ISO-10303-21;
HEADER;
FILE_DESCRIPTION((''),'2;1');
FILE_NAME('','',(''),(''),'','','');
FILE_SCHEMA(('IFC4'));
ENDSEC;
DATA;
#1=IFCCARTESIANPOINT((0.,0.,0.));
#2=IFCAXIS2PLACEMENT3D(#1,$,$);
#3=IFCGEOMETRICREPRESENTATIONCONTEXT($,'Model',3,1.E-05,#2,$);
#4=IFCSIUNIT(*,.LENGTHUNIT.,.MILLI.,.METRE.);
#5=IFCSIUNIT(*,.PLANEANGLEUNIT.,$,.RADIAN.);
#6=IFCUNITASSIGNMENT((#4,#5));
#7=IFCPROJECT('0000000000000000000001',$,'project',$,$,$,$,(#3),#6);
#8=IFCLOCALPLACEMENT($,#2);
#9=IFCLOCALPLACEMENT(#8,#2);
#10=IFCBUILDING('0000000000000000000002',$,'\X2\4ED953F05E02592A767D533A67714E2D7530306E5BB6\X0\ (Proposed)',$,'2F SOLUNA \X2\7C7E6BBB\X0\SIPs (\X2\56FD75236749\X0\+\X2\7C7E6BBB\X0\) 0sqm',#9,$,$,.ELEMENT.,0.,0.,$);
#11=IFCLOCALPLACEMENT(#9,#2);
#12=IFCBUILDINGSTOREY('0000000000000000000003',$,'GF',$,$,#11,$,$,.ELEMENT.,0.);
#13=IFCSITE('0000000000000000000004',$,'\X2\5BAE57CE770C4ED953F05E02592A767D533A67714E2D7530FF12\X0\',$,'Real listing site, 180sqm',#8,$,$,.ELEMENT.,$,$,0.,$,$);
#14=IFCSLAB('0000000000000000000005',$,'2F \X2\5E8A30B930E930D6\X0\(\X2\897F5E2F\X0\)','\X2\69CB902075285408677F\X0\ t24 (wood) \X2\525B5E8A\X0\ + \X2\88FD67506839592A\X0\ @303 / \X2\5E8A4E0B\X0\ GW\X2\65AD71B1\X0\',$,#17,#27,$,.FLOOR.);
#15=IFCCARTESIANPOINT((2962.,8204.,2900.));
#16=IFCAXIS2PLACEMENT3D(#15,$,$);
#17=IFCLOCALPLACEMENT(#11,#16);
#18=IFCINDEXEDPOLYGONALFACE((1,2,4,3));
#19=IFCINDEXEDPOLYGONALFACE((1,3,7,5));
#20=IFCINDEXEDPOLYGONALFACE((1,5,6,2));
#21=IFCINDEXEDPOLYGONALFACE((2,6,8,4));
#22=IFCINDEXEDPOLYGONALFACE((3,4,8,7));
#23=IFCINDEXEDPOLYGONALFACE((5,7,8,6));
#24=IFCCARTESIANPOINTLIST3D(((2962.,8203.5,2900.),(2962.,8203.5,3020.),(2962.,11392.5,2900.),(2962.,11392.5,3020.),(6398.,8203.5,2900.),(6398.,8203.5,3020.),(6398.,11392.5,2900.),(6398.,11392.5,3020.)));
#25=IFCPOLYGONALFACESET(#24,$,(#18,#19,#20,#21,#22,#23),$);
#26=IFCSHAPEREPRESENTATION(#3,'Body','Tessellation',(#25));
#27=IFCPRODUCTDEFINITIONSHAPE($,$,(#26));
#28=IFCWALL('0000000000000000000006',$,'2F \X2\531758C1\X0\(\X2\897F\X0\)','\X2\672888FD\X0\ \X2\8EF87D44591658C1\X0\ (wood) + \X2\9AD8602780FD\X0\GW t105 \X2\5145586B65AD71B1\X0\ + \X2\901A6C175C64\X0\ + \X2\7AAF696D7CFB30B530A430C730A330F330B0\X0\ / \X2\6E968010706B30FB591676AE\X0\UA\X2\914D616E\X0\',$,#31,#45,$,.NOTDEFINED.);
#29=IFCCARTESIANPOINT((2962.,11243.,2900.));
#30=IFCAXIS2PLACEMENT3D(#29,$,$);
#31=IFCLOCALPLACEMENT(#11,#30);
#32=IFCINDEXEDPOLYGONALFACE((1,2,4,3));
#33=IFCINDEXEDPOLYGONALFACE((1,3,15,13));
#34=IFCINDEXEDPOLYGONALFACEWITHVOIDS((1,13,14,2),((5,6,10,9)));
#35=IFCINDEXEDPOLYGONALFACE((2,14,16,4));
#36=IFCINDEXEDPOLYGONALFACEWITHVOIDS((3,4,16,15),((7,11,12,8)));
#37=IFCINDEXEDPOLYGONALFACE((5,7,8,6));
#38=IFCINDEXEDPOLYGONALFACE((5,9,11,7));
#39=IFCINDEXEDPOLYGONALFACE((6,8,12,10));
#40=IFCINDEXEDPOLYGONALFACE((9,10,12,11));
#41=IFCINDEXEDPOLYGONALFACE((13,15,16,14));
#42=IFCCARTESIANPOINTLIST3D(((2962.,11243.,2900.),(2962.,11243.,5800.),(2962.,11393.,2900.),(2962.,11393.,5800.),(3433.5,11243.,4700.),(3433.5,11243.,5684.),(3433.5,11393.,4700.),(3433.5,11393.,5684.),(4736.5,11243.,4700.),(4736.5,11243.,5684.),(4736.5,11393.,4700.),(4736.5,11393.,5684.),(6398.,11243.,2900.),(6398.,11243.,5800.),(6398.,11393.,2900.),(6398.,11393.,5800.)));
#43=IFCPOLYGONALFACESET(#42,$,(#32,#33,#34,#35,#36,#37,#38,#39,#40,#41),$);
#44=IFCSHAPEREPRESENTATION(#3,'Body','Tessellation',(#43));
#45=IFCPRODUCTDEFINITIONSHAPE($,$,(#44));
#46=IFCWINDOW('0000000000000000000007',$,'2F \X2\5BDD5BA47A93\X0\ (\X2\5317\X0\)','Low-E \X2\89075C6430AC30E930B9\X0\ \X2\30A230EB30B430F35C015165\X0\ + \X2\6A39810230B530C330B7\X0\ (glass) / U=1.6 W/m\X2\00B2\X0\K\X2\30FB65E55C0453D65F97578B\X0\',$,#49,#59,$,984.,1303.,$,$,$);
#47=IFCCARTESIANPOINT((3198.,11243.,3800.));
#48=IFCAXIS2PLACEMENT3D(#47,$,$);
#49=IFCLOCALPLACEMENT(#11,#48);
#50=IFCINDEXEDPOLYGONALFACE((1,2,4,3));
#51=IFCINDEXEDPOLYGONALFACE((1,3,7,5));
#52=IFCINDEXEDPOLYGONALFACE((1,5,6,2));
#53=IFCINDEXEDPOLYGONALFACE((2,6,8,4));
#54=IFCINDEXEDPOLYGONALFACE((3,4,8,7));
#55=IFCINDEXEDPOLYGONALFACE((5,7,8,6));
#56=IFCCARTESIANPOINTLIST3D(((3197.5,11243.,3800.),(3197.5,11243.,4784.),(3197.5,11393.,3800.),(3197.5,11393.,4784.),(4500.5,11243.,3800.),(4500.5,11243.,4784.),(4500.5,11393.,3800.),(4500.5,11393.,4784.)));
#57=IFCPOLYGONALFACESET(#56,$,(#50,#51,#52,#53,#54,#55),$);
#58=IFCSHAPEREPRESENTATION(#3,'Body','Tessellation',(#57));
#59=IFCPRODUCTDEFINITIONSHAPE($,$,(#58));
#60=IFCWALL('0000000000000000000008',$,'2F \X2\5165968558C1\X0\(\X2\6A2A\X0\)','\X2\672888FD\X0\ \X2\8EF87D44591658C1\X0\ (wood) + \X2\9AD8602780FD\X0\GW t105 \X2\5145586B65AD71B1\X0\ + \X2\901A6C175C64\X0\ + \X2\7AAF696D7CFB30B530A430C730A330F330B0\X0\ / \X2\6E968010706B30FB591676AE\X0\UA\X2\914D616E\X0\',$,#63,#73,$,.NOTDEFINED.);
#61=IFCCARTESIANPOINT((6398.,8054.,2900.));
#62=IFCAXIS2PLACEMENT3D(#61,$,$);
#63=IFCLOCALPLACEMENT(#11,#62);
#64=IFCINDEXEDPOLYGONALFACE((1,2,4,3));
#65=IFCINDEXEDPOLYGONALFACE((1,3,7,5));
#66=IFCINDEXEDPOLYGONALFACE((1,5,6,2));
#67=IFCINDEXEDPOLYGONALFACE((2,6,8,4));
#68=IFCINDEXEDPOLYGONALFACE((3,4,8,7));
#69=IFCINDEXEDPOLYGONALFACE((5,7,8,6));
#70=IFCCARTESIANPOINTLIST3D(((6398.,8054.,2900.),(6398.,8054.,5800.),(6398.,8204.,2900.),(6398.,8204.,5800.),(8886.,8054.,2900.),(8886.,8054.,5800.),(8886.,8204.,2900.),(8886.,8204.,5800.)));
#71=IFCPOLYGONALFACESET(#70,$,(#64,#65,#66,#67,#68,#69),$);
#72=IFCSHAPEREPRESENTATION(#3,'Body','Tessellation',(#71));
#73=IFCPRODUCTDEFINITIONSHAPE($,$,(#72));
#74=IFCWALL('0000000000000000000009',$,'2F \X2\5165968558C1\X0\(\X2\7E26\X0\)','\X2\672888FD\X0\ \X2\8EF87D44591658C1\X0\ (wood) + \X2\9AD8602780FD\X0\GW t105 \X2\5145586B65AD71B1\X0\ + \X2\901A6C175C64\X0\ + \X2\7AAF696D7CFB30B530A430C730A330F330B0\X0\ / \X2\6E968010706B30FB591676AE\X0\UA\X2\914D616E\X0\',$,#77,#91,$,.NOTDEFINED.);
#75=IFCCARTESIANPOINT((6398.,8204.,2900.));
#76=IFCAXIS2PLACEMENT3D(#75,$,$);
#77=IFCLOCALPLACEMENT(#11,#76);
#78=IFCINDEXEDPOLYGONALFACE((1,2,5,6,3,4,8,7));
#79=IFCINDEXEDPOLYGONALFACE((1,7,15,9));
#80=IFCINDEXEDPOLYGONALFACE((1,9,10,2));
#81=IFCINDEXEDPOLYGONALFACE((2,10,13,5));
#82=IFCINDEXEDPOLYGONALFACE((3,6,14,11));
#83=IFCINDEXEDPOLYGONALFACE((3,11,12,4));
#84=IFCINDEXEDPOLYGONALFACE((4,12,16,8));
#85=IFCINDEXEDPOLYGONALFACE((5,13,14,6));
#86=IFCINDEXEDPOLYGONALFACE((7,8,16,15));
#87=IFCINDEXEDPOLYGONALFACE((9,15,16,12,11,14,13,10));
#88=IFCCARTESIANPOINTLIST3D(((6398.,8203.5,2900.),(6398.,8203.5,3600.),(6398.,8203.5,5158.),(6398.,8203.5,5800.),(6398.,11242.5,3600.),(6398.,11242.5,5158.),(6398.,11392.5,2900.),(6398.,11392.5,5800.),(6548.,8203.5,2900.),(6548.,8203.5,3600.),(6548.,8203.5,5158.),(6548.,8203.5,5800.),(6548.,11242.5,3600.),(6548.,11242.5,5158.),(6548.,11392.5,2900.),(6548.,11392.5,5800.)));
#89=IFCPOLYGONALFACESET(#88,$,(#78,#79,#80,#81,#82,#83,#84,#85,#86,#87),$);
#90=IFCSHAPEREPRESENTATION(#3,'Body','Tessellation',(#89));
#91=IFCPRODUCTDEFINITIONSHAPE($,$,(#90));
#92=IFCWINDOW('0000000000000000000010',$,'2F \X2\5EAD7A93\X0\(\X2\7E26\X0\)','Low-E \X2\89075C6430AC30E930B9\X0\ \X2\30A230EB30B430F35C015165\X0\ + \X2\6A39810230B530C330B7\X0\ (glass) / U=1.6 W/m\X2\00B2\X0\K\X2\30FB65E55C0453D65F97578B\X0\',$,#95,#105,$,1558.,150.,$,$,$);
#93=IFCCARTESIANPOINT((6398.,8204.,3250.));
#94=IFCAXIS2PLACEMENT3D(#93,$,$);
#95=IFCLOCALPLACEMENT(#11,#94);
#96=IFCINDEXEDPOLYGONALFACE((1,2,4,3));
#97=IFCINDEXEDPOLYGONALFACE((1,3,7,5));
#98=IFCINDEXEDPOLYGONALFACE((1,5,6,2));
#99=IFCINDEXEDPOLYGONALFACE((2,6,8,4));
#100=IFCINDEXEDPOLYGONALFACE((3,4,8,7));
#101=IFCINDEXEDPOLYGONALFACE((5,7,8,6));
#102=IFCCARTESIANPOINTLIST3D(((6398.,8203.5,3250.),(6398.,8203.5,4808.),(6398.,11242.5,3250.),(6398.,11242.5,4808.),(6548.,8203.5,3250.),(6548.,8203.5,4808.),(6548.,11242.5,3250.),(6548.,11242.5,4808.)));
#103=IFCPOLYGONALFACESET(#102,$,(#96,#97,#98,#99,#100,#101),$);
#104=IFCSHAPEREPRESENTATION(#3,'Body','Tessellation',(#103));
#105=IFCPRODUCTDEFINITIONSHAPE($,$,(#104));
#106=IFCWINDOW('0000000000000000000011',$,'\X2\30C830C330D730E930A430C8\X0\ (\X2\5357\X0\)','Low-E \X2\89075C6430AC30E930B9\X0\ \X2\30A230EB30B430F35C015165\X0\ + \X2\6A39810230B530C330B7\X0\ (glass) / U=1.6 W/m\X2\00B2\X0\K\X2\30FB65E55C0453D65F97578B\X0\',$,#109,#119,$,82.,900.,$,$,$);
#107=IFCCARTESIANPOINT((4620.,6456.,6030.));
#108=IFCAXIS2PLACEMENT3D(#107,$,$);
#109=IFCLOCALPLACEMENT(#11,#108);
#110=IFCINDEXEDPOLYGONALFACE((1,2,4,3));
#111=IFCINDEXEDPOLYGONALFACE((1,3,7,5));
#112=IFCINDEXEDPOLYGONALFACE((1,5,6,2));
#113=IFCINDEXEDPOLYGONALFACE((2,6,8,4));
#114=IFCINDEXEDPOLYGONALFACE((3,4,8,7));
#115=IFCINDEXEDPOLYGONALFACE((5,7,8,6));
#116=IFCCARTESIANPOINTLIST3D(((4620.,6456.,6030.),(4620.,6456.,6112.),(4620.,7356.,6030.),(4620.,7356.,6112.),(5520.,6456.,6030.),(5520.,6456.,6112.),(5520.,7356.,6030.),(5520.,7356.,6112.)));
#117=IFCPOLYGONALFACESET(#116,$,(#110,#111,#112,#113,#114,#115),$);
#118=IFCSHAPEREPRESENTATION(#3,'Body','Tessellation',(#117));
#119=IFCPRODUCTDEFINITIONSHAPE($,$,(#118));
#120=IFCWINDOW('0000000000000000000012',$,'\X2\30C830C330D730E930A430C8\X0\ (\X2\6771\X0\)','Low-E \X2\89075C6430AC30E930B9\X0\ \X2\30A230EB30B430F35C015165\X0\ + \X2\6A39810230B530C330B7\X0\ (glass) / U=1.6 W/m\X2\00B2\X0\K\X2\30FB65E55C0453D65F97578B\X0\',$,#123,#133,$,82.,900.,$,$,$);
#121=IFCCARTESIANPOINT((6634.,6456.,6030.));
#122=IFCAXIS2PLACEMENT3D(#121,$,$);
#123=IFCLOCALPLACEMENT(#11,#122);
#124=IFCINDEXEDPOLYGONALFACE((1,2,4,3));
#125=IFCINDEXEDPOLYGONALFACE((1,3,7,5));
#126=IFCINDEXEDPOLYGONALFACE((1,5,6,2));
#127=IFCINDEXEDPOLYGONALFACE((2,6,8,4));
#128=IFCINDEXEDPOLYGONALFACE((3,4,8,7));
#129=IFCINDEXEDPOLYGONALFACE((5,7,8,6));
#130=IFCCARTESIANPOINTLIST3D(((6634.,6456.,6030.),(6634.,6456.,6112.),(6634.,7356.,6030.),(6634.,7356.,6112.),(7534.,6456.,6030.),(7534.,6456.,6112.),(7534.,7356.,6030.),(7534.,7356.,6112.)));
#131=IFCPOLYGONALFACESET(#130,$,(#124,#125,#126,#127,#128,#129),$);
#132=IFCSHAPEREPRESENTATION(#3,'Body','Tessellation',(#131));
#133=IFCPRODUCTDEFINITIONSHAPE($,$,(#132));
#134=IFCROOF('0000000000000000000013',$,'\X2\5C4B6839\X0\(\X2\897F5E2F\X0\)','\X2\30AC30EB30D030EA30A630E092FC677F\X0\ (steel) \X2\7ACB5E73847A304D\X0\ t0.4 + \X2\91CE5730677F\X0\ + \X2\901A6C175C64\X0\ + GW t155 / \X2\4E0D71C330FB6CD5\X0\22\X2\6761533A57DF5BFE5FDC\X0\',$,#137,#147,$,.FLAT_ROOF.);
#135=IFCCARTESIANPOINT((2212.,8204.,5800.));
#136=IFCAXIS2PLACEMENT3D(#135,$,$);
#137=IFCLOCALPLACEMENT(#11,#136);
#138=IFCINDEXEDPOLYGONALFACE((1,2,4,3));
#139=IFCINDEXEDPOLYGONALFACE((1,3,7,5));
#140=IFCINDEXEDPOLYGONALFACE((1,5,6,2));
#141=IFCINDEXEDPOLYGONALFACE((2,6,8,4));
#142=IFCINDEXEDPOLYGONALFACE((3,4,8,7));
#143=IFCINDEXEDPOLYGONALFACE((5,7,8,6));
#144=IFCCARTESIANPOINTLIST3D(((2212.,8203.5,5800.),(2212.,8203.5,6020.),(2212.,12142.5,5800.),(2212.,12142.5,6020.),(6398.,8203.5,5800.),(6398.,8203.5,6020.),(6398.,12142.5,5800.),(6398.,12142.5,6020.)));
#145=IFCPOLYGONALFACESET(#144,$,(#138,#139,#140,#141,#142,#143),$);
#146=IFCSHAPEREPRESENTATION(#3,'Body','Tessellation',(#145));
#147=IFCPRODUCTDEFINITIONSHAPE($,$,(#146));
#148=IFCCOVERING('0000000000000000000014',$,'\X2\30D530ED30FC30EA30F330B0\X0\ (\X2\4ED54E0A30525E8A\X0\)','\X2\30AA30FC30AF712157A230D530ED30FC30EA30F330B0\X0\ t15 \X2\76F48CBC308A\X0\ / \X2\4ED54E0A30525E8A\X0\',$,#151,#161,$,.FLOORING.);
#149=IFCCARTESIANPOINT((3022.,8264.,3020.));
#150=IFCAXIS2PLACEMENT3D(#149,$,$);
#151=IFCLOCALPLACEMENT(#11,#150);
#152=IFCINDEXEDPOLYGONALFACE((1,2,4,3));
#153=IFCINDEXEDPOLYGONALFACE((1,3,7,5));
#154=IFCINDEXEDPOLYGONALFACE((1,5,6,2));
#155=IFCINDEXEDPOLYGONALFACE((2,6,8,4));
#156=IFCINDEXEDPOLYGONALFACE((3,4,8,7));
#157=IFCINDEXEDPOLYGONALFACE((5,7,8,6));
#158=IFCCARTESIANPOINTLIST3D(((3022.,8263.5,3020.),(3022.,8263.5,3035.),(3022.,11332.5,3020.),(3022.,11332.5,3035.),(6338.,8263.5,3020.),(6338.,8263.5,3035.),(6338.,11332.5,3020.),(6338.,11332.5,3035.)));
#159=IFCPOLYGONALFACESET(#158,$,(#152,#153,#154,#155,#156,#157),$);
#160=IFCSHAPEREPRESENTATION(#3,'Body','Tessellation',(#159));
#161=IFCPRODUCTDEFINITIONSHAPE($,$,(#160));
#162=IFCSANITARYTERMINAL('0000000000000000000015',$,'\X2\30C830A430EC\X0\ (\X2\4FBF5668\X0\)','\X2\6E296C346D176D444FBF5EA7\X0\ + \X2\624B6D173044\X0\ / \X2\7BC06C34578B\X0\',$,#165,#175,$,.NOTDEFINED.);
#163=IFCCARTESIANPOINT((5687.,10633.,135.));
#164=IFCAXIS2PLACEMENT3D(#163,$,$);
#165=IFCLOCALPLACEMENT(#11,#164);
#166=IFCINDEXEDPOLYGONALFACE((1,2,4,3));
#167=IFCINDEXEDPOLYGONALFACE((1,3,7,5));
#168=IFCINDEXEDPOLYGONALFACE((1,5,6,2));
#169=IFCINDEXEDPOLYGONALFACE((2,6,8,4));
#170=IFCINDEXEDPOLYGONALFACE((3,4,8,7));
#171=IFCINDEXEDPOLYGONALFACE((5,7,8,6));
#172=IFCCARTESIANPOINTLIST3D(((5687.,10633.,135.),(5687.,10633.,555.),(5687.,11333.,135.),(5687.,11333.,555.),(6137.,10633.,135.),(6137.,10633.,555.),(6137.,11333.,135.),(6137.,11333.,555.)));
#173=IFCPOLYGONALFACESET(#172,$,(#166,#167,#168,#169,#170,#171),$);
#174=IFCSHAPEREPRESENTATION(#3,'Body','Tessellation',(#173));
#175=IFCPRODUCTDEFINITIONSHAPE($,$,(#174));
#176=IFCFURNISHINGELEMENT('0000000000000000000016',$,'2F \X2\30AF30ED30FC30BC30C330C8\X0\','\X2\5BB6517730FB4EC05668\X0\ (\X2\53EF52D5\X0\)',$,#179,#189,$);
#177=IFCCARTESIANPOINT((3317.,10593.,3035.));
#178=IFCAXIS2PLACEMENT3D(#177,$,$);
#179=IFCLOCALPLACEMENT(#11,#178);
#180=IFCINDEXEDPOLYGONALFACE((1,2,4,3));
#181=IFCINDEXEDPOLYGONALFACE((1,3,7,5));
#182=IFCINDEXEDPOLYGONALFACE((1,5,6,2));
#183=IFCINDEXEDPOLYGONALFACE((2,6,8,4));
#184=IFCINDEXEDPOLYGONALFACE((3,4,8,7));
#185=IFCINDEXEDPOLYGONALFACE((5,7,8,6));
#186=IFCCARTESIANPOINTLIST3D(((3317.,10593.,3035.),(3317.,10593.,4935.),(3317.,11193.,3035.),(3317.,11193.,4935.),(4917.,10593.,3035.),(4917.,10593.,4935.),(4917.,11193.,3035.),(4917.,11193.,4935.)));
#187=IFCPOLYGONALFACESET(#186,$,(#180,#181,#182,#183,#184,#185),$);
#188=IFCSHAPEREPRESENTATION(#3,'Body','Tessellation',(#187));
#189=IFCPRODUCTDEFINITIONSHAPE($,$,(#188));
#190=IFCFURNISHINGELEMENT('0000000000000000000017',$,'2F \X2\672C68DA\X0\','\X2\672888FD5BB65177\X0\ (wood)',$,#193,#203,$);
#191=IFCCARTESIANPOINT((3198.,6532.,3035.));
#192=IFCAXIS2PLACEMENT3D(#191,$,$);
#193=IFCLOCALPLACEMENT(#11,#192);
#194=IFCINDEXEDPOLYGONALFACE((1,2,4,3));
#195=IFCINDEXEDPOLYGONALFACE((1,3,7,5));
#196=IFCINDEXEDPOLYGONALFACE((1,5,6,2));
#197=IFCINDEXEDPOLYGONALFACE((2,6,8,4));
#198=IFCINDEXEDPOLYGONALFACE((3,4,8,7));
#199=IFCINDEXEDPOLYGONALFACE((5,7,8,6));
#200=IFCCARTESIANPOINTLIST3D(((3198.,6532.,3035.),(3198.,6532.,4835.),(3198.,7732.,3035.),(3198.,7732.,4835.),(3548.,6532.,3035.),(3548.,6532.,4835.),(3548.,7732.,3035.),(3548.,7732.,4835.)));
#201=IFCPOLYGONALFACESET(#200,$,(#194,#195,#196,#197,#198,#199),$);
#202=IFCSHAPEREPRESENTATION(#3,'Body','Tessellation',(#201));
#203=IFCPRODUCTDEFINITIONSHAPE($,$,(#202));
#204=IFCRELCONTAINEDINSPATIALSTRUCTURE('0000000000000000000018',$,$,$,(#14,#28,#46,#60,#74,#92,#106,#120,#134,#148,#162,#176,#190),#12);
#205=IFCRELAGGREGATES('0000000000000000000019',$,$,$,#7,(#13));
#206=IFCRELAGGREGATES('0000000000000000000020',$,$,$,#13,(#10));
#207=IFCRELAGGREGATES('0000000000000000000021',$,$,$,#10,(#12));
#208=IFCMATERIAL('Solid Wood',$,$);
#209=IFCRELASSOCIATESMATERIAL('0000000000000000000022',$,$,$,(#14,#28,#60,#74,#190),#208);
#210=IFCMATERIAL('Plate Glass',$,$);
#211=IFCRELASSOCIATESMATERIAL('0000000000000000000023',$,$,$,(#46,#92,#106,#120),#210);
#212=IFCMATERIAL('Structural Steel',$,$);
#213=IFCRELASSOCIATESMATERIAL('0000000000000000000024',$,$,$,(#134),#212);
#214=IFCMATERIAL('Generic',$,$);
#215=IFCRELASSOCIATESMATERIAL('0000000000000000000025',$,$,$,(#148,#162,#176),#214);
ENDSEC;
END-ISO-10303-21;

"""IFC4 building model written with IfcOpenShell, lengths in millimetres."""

from ifc_helpers import new_model, si_unit, frame, frame_2d, origin, place, context, project, spatial, rectangle, extrude, material, element, fill, save


model = new_model("IFC4")

# Units and contexts
model_context = context("Model", 3, precision=1e-05, world=origin())
ifc_project = project(units=[si_unit("LENGTHUNIT", "METRE", prefix="MILLI"), si_unit("PLANEANGLEUNIT", "RADIAN")], contexts=[model_context])

# Site, building, storey
site_placement = place(None, origin())
site = spatial("IfcSite", under=ifc_project, at=site_placement, Name="宮城県仙台市太白区東中田２", ObjectType="Real listing site, 180sqm", CompositionType="ELEMENT", RefElevation=0.0)
building_placement = place(site_placement, origin())
building = spatial("IfcBuilding", under=site, at=building_placement, Name="仙台市太白区東中田の家 (Proposed)", ObjectType="2F SOLUNA 籾殻SIPs (国産杉+籾殻) 0sqm", CompositionType="ELEMENT", ElevationOfRefHeight=0.0, ElevationOfTerrain=0.0)
storey_placement = place(building_placement, origin())
storey = spatial("IfcBuildingStorey", under=building, at=storey_placement, Name="GF", CompositionType="ELEMENT", Elevation=0.0)

# Slab
ifc_material_1 = material(Name="Solid Wood")
slab_placement = place(storey_placement, frame((2962.0, 8204.0, 2900.0)))
element("IfcSlab", 1, at=slab_placement, inside=storey, material=ifc_material_1, Name="2F 床スラブ(西帯)", Description="構造用合板 t24 (wood) 剛床 + 製材根太 @303 / 床下 GW断熱", PredefinedType="FLOOR", context=model_context, shape_type="SweptSolid", body=[
    extrude(rectangle(XDim=3436.0, YDim=3189.0, at=frame_2d((1718.0, 1594.0))), frame((2962.0, 8204.0, 2900.0)), (0.0, 0.0, 1.0), 120.0),
])

# Wall, opening, window
wall_1_placement = place(storey_placement, frame((2962.0, 11243.0, 2900.0)))
wall_1 = element("IfcWall", 2, at=wall_1_placement, inside=storey, material=ifc_material_1, Name="2F 北壁(西)", Description="木製 軸組外壁 (wood) + 高性能GW t105 充填断熱 + 通気層 + 窯業系サイディング / 準耐火・外皮UA配慮", PredefinedType="NOTDEFINED", context=model_context, shape_type="SweptSolid", body=[
    extrude(rectangle(XDim=3436.0, YDim=150.0, at=frame_2d((1718.0, 75.0))), frame((2962.0, 11243.0, 2900.0)), (0.0, 0.0, 1.0), 2900.0),
])
opening_1_placement = place(storey_placement, frame((3198.0, 11243.0, 3800.0)))
opening_1 = element("IfcOpeningElement", 3, at=opening_1_placement, cuts=wall_1, PredefinedType="NOTDEFINED", context=model_context, shape_type="SweptSolid", body=[
    extrude(rectangle(XDim=1303.0, YDim=150.0, at=frame_2d((651.0, 75.0))), frame((3198.0, 11243.0, 3800.0)), (0.0, 0.0, 1.0), 984.0),
])
ifc_material_2 = material(Name="Plate Glass")
window_1_placement = place(storey_placement, frame((3198.0, 11243.0, 3800.0)))
window_1 = element("IfcWindow", 4, at=window_1_placement, inside=storey, material=ifc_material_2, Name="2F 寝室窓 (北)", Description="Low-E 複層ガラス アルゴン封入 + 樹脂サッシ (glass) / U=1.6 W/m²K・日射取得型", OverallHeight=984.0, OverallWidth=1303.0, context=model_context, shape_type="SweptSolid", body=[
    extrude(rectangle(XDim=1303.0, YDim=150.0, at=frame_2d((651.0, 75.0))), frame((3198.0, 11243.0, 3800.0)), (0.0, 0.0, 1.0), 984.0),
])
fill(opening_1, window_1)

# Wall
wall_2_placement = place(storey_placement, frame((6398.0, 8054.0, 2900.0)))
element("IfcWall", 5, at=wall_2_placement, inside=storey, material=ifc_material_1, Name="2F 入隅壁(横)", Description="木製 軸組外壁 (wood) + 高性能GW t105 充填断熱 + 通気層 + 窯業系サイディング / 準耐火・外皮UA配慮", PredefinedType="NOTDEFINED", context=model_context, shape_type="SweptSolid", body=[
    extrude(rectangle(XDim=2488.0, YDim=150.0, at=frame_2d((1244.0, 75.0))), frame((6398.0, 8054.0, 2900.0)), (0.0, 0.0, 1.0), 2900.0),
])

# Wall, opening, window
wall_3_placement = place(storey_placement, frame((6398.0, 8204.0, 2900.0)))
wall_3 = element("IfcWall", 6, at=wall_3_placement, inside=storey, material=ifc_material_1, Name="2F 入隅壁(縦)", Description="木製 軸組外壁 (wood) + 高性能GW t105 充填断熱 + 通気層 + 窯業系サイディング / 準耐火・外皮UA配慮", PredefinedType="NOTDEFINED", context=model_context, shape_type="SweptSolid", body=[
    extrude(rectangle(XDim=150.0, YDim=3189.0, at=frame_2d((75.0, 1594.0))), frame((6398.0, 8204.0, 2900.0)), (0.0, 0.0, 1.0), 2900.0),
])
opening_2_placement = place(storey_placement, frame((6398.0, 8204.0, 3250.0)))
opening_2 = element("IfcOpeningElement", 7, at=opening_2_placement, cuts=wall_3, PredefinedType="NOTDEFINED", context=model_context, shape_type="SweptSolid", body=[
    extrude(rectangle(XDim=150.0, YDim=3039.0, at=frame_2d((75.0, 1519.0))), frame((6398.0, 8204.0, 3250.0)), (0.0, 0.0, 1.0), 1558.0),
])
window_2_placement = place(storey_placement, frame((6398.0, 8204.0, 3250.0)))
window_2 = element("IfcWindow", 8, at=window_2_placement, inside=storey, material=ifc_material_2, Name="2F 庭窓(縦)", Description="Low-E 複層ガラス アルゴン封入 + 樹脂サッシ (glass) / U=1.6 W/m²K・日射取得型", OverallHeight=1558.0, OverallWidth=150.0, context=model_context, shape_type="SweptSolid", body=[
    extrude(rectangle(XDim=150.0, YDim=3039.0, at=frame_2d((75.0, 1519.0))), frame((6398.0, 8204.0, 3250.0)), (0.0, 0.0, 1.0), 1558.0),
])
fill(opening_2, window_2)

# Windows
window_3_placement = place(storey_placement, frame((4620.0, 6456.0, 6030.0)))
element("IfcWindow", 9, at=window_3_placement, inside=storey, material=ifc_material_2, Name="トップライト (南)", Description="Low-E 複層ガラス アルゴン封入 + 樹脂サッシ (glass) / U=1.6 W/m²K・日射取得型", OverallHeight=82.0, OverallWidth=900.0, context=model_context, shape_type="SweptSolid", body=[
    extrude(rectangle(XDim=900.0, YDim=900.0, at=frame_2d((450.0, 450.0))), frame((4620.0, 6456.0, 6030.0)), (0.0, 0.0, 1.0), 82.0),
])
window_4_placement = place(storey_placement, frame((6634.0, 6456.0, 6030.0)))
element("IfcWindow", 10, at=window_4_placement, inside=storey, material=ifc_material_2, Name="トップライト (東)", Description="Low-E 複層ガラス アルゴン封入 + 樹脂サッシ (glass) / U=1.6 W/m²K・日射取得型", OverallHeight=82.0, OverallWidth=900.0, context=model_context, shape_type="SweptSolid", body=[
    extrude(rectangle(XDim=900.0, YDim=900.0, at=frame_2d((450.0, 450.0))), frame((6634.0, 6456.0, 6030.0)), (0.0, 0.0, 1.0), 82.0),
])

# Roof
ifc_material_3 = material(Name="Structural Steel")
for number, where, name in (
    (11, (2212.0, 8204.0, 5800.0), "屋根(西帯)"),
):
    element("IfcRoof", number, at=place(storey_placement, frame(where)), inside=storey, material=ifc_material_3, Name=name, Description="ガルバリウム鋼板 (steel) 立平葺き t0.4 + 野地板 + 通気層 + GW t155 / 不燃・法22条区域対応", PredefinedType="FLAT_ROOF", context=model_context, shape_type="SweptSolid", body=[
        extrude(rectangle(XDim=4186.0, YDim=3939.0, at=frame_2d((2093.0, 1969.0))), frame((2212.0, 8204.0, 5800.0)), (0.0, 0.0, 1.0), 220.0),
    ])

# Covering
ifc_material_4 = material(Name="Generic")
covering_placement = place(storey_placement, frame((3022.0, 8264.0, 3020.0)))
element("IfcCovering", 12, at=covering_placement, inside=storey, material=ifc_material_4, Name="フローリング (仕上げ床)", Description="オーク無垢フローリング t15 直貼り / 仕上げ床", PredefinedType="FLOORING", context=model_context, shape_type="SweptSolid", body=[
    extrude(rectangle(XDim=3316.0, YDim=3069.0, at=frame_2d((1658.0, 1534.0))), frame((3022.0, 8264.0, 3020.0)), (0.0, 0.0, 1.0), 15.0),
])

# Sanitary terminal
sanitary_terminal_placement = place(storey_placement, frame((5687.0, 10633.0, 135.0)))
element("IfcSanitaryTerminal", 13, at=sanitary_terminal_placement, inside=storey, material=ifc_material_4, Name="トイレ (便器)", Description="温水洗浄便座 + 手洗い / 節水型", PredefinedType="NOTDEFINED", context=model_context, shape_type="SweptSolid", body=[
    extrude(rectangle(XDim=450.0, YDim=700.0, at=frame_2d((225.0, 350.0))), frame((5687.0, 10633.0, 135.0)), (0.0, 0.0, 1.0), 420.0),
])

# Furnishing elements
furnishing_1_placement = place(storey_placement, frame((3317.0, 10593.0, 3035.0)))
element("IfcFurnishingElement", 14, at=furnishing_1_placement, inside=storey, material=ifc_material_4, Name="2F クローゼット", Description="家具・什器 (可動)", context=model_context, shape_type="SweptSolid", body=[
    extrude(rectangle(XDim=1600.0, YDim=600.0, at=frame_2d((800.0, 300.0))), frame((3317.0, 10593.0, 3035.0)), (0.0, 0.0, 1.0), 1900.0),
])
furnishing_2_placement = place(storey_placement, frame((3198.0, 6532.0, 3035.0)))
element("IfcFurnishingElement", 15, at=furnishing_2_placement, inside=storey, material=ifc_material_1, Name="2F 本棚", Description="木製家具 (wood)", context=model_context, shape_type="SweptSolid", body=[
    extrude(rectangle(XDim=350.0, YDim=1200.0, at=frame_2d((175.0, 600.0))), frame((3198.0, 6532.0, 3035.0)), (0.0, 0.0, 1.0), 1800.0),
])

save(model, "model.ifc")
